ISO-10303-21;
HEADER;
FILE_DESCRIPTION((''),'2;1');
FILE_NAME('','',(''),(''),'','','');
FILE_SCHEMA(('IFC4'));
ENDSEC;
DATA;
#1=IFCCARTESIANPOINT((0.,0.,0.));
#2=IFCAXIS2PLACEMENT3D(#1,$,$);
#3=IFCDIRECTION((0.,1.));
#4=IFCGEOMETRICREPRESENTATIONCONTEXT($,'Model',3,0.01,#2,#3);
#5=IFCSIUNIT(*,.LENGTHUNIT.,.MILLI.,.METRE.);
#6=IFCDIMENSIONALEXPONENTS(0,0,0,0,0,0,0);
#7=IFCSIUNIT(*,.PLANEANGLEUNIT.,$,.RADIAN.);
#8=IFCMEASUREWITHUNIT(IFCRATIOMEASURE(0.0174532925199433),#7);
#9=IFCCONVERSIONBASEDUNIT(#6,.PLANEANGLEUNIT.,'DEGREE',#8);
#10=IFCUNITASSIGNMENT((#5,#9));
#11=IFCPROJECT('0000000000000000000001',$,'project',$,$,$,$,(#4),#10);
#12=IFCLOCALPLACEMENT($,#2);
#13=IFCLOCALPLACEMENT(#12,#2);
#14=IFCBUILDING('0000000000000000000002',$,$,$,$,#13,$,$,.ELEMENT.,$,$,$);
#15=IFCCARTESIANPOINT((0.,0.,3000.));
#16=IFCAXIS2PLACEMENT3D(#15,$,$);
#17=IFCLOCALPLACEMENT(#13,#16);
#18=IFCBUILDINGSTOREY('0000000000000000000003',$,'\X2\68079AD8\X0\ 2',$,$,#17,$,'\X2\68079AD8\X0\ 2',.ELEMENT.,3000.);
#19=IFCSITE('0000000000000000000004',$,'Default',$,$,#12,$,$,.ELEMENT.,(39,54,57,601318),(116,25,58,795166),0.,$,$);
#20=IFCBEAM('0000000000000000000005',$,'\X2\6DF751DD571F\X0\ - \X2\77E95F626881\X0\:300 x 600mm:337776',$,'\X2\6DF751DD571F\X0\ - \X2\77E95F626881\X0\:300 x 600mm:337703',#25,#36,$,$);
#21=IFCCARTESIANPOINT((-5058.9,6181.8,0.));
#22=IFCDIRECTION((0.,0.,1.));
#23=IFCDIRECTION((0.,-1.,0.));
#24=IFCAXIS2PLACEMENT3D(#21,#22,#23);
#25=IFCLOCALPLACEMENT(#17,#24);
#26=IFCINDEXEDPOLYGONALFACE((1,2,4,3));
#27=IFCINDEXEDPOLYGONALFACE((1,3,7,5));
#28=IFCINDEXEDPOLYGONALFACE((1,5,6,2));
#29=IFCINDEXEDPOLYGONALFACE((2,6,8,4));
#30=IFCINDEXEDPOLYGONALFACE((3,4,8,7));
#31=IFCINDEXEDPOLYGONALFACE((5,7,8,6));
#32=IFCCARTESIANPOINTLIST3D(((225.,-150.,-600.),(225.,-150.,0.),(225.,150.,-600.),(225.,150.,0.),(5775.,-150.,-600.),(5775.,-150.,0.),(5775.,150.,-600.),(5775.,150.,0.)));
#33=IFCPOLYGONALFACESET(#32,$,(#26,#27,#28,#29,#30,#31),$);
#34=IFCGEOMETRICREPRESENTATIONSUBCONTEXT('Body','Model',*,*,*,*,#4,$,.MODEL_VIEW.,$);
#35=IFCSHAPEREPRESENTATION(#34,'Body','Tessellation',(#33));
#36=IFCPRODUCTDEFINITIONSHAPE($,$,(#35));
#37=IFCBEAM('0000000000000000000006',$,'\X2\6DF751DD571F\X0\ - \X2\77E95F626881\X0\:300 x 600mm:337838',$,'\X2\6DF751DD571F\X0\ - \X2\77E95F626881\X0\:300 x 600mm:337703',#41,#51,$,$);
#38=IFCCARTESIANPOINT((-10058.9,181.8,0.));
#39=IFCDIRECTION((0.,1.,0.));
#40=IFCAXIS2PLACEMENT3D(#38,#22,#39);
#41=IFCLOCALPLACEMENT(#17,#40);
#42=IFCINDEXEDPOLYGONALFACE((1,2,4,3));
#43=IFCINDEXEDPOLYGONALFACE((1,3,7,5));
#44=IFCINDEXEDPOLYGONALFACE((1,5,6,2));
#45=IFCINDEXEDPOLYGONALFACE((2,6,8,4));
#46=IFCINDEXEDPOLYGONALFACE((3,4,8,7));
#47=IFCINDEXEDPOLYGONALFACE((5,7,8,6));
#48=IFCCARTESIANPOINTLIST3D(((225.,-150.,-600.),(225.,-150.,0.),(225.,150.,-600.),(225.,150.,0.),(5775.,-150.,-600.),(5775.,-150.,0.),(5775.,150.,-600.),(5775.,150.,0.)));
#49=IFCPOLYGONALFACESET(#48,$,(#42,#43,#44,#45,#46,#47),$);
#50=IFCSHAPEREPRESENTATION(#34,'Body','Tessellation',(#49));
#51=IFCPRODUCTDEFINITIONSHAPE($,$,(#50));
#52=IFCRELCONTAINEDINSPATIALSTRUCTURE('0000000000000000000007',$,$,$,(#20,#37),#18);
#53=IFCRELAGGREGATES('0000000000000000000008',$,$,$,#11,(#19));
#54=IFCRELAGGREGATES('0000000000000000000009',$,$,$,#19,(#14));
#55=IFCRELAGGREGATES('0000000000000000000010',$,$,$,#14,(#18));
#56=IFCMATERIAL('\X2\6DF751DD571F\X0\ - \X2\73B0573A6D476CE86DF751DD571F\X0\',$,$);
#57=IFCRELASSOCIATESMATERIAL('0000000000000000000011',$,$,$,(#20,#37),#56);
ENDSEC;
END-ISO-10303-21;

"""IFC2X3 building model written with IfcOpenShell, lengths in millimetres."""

from ifc_helpers import new_model, entity, si_unit, converted_unit, direction, frame, frame_2d, origin, place, context, subcontext, project, spatial, rectangle, extrude, material, element, save


model = new_model("IFC2X3")

# Units and contexts
model_context = context("Model", 3, precision=0.01, world=origin(), true_north=direction((0.0, 1.0)))
body_context = subcontext(model_context, "Body", "Model", "MODEL_VIEW")
ifc_project = project(units=[si_unit("LENGTHUNIT", "METRE", prefix="MILLI"), converted_unit("PLANEANGLEUNIT", "DEGREE", entity("IfcRatioMeasure", 0.0174532925199433), si_unit("PLANEANGLEUNIT", "RADIAN"), dimensions=[0, 0, 0, 0, 0, 0, 0])], contexts=[model_context])

# Site, building, storey
site_placement = place(None, origin())
site = spatial("IfcSite", under=ifc_project, at=site_placement, Name="Default", CompositionType="ELEMENT", RefLatitude=(39, 54, 57, 601318), RefLongitude=(116, 25, 58, 795166), RefElevation=0.0)
building_placement = place(site_placement, origin())
building = spatial("IfcBuilding", under=site, at=building_placement, CompositionType="ELEMENT")
storey_placement = place(building_placement, frame((0.0, 0.0, 3000.0)))
storey = spatial("IfcBuildingStorey", under=building, at=storey_placement, Name="标高 2", LongName="标高 2", CompositionType="ELEMENT", Elevation=3000.0)

# Beams
ifc_material = material(Name="混凝土 - 现场浇注混凝土")
beam_1_placement = place(storey_placement, frame((-5058.9, 6181.8, 0.0), z_axis=(0.0, 0.0, 1.0), x_axis=(0.0, -1.0, 0.0)))
element("IfcBeam", 1, at=beam_1_placement, inside=storey, material=ifc_material, Name="混凝土 - 矩形梁:300 x 600mm:337776", ObjectType="混凝土 - 矩形梁:300 x 600mm:337703", context=body_context, shape_type="SweptSolid", body=[
    extrude(rectangle(XDim=600.0, YDim=300.0, at=frame_2d((0.0, 0.0), x_axis=(1.0, 0.0))), frame((225.0, 0.0, -300.0), z_axis=(1.0, 0.0, 0.0), x_axis=(0.0, 0.0, -1.0)), (0.0, 0.0, 1.0), 5550.0),
])
beam_2_placement = place(storey_placement, frame((-10058.9, 181.8, 0.0), z_axis=(0.0, 0.0, 1.0), x_axis=(0.0, 1.0, 0.0)))
element("IfcBeam", 2, at=beam_2_placement, inside=storey, material=ifc_material, Name="混凝土 - 矩形梁:300 x 600mm:337838", ObjectType="混凝土 - 矩形梁:300 x 600mm:337703", context=body_context, shape_type="SweptSolid", body=[
    extrude(rectangle(XDim=600.0, YDim=300.0, at=frame_2d((0.0, 0.0), x_axis=(1.0, 0.0))), frame((225.0, 0.0, -300.0), z_axis=(1.0, 0.0, 0.0), x_axis=(0.0, 0.0, -1.0)), (0.0, 0.0, 1.0), 5550.0),
])

save(model, "model.ifc")
